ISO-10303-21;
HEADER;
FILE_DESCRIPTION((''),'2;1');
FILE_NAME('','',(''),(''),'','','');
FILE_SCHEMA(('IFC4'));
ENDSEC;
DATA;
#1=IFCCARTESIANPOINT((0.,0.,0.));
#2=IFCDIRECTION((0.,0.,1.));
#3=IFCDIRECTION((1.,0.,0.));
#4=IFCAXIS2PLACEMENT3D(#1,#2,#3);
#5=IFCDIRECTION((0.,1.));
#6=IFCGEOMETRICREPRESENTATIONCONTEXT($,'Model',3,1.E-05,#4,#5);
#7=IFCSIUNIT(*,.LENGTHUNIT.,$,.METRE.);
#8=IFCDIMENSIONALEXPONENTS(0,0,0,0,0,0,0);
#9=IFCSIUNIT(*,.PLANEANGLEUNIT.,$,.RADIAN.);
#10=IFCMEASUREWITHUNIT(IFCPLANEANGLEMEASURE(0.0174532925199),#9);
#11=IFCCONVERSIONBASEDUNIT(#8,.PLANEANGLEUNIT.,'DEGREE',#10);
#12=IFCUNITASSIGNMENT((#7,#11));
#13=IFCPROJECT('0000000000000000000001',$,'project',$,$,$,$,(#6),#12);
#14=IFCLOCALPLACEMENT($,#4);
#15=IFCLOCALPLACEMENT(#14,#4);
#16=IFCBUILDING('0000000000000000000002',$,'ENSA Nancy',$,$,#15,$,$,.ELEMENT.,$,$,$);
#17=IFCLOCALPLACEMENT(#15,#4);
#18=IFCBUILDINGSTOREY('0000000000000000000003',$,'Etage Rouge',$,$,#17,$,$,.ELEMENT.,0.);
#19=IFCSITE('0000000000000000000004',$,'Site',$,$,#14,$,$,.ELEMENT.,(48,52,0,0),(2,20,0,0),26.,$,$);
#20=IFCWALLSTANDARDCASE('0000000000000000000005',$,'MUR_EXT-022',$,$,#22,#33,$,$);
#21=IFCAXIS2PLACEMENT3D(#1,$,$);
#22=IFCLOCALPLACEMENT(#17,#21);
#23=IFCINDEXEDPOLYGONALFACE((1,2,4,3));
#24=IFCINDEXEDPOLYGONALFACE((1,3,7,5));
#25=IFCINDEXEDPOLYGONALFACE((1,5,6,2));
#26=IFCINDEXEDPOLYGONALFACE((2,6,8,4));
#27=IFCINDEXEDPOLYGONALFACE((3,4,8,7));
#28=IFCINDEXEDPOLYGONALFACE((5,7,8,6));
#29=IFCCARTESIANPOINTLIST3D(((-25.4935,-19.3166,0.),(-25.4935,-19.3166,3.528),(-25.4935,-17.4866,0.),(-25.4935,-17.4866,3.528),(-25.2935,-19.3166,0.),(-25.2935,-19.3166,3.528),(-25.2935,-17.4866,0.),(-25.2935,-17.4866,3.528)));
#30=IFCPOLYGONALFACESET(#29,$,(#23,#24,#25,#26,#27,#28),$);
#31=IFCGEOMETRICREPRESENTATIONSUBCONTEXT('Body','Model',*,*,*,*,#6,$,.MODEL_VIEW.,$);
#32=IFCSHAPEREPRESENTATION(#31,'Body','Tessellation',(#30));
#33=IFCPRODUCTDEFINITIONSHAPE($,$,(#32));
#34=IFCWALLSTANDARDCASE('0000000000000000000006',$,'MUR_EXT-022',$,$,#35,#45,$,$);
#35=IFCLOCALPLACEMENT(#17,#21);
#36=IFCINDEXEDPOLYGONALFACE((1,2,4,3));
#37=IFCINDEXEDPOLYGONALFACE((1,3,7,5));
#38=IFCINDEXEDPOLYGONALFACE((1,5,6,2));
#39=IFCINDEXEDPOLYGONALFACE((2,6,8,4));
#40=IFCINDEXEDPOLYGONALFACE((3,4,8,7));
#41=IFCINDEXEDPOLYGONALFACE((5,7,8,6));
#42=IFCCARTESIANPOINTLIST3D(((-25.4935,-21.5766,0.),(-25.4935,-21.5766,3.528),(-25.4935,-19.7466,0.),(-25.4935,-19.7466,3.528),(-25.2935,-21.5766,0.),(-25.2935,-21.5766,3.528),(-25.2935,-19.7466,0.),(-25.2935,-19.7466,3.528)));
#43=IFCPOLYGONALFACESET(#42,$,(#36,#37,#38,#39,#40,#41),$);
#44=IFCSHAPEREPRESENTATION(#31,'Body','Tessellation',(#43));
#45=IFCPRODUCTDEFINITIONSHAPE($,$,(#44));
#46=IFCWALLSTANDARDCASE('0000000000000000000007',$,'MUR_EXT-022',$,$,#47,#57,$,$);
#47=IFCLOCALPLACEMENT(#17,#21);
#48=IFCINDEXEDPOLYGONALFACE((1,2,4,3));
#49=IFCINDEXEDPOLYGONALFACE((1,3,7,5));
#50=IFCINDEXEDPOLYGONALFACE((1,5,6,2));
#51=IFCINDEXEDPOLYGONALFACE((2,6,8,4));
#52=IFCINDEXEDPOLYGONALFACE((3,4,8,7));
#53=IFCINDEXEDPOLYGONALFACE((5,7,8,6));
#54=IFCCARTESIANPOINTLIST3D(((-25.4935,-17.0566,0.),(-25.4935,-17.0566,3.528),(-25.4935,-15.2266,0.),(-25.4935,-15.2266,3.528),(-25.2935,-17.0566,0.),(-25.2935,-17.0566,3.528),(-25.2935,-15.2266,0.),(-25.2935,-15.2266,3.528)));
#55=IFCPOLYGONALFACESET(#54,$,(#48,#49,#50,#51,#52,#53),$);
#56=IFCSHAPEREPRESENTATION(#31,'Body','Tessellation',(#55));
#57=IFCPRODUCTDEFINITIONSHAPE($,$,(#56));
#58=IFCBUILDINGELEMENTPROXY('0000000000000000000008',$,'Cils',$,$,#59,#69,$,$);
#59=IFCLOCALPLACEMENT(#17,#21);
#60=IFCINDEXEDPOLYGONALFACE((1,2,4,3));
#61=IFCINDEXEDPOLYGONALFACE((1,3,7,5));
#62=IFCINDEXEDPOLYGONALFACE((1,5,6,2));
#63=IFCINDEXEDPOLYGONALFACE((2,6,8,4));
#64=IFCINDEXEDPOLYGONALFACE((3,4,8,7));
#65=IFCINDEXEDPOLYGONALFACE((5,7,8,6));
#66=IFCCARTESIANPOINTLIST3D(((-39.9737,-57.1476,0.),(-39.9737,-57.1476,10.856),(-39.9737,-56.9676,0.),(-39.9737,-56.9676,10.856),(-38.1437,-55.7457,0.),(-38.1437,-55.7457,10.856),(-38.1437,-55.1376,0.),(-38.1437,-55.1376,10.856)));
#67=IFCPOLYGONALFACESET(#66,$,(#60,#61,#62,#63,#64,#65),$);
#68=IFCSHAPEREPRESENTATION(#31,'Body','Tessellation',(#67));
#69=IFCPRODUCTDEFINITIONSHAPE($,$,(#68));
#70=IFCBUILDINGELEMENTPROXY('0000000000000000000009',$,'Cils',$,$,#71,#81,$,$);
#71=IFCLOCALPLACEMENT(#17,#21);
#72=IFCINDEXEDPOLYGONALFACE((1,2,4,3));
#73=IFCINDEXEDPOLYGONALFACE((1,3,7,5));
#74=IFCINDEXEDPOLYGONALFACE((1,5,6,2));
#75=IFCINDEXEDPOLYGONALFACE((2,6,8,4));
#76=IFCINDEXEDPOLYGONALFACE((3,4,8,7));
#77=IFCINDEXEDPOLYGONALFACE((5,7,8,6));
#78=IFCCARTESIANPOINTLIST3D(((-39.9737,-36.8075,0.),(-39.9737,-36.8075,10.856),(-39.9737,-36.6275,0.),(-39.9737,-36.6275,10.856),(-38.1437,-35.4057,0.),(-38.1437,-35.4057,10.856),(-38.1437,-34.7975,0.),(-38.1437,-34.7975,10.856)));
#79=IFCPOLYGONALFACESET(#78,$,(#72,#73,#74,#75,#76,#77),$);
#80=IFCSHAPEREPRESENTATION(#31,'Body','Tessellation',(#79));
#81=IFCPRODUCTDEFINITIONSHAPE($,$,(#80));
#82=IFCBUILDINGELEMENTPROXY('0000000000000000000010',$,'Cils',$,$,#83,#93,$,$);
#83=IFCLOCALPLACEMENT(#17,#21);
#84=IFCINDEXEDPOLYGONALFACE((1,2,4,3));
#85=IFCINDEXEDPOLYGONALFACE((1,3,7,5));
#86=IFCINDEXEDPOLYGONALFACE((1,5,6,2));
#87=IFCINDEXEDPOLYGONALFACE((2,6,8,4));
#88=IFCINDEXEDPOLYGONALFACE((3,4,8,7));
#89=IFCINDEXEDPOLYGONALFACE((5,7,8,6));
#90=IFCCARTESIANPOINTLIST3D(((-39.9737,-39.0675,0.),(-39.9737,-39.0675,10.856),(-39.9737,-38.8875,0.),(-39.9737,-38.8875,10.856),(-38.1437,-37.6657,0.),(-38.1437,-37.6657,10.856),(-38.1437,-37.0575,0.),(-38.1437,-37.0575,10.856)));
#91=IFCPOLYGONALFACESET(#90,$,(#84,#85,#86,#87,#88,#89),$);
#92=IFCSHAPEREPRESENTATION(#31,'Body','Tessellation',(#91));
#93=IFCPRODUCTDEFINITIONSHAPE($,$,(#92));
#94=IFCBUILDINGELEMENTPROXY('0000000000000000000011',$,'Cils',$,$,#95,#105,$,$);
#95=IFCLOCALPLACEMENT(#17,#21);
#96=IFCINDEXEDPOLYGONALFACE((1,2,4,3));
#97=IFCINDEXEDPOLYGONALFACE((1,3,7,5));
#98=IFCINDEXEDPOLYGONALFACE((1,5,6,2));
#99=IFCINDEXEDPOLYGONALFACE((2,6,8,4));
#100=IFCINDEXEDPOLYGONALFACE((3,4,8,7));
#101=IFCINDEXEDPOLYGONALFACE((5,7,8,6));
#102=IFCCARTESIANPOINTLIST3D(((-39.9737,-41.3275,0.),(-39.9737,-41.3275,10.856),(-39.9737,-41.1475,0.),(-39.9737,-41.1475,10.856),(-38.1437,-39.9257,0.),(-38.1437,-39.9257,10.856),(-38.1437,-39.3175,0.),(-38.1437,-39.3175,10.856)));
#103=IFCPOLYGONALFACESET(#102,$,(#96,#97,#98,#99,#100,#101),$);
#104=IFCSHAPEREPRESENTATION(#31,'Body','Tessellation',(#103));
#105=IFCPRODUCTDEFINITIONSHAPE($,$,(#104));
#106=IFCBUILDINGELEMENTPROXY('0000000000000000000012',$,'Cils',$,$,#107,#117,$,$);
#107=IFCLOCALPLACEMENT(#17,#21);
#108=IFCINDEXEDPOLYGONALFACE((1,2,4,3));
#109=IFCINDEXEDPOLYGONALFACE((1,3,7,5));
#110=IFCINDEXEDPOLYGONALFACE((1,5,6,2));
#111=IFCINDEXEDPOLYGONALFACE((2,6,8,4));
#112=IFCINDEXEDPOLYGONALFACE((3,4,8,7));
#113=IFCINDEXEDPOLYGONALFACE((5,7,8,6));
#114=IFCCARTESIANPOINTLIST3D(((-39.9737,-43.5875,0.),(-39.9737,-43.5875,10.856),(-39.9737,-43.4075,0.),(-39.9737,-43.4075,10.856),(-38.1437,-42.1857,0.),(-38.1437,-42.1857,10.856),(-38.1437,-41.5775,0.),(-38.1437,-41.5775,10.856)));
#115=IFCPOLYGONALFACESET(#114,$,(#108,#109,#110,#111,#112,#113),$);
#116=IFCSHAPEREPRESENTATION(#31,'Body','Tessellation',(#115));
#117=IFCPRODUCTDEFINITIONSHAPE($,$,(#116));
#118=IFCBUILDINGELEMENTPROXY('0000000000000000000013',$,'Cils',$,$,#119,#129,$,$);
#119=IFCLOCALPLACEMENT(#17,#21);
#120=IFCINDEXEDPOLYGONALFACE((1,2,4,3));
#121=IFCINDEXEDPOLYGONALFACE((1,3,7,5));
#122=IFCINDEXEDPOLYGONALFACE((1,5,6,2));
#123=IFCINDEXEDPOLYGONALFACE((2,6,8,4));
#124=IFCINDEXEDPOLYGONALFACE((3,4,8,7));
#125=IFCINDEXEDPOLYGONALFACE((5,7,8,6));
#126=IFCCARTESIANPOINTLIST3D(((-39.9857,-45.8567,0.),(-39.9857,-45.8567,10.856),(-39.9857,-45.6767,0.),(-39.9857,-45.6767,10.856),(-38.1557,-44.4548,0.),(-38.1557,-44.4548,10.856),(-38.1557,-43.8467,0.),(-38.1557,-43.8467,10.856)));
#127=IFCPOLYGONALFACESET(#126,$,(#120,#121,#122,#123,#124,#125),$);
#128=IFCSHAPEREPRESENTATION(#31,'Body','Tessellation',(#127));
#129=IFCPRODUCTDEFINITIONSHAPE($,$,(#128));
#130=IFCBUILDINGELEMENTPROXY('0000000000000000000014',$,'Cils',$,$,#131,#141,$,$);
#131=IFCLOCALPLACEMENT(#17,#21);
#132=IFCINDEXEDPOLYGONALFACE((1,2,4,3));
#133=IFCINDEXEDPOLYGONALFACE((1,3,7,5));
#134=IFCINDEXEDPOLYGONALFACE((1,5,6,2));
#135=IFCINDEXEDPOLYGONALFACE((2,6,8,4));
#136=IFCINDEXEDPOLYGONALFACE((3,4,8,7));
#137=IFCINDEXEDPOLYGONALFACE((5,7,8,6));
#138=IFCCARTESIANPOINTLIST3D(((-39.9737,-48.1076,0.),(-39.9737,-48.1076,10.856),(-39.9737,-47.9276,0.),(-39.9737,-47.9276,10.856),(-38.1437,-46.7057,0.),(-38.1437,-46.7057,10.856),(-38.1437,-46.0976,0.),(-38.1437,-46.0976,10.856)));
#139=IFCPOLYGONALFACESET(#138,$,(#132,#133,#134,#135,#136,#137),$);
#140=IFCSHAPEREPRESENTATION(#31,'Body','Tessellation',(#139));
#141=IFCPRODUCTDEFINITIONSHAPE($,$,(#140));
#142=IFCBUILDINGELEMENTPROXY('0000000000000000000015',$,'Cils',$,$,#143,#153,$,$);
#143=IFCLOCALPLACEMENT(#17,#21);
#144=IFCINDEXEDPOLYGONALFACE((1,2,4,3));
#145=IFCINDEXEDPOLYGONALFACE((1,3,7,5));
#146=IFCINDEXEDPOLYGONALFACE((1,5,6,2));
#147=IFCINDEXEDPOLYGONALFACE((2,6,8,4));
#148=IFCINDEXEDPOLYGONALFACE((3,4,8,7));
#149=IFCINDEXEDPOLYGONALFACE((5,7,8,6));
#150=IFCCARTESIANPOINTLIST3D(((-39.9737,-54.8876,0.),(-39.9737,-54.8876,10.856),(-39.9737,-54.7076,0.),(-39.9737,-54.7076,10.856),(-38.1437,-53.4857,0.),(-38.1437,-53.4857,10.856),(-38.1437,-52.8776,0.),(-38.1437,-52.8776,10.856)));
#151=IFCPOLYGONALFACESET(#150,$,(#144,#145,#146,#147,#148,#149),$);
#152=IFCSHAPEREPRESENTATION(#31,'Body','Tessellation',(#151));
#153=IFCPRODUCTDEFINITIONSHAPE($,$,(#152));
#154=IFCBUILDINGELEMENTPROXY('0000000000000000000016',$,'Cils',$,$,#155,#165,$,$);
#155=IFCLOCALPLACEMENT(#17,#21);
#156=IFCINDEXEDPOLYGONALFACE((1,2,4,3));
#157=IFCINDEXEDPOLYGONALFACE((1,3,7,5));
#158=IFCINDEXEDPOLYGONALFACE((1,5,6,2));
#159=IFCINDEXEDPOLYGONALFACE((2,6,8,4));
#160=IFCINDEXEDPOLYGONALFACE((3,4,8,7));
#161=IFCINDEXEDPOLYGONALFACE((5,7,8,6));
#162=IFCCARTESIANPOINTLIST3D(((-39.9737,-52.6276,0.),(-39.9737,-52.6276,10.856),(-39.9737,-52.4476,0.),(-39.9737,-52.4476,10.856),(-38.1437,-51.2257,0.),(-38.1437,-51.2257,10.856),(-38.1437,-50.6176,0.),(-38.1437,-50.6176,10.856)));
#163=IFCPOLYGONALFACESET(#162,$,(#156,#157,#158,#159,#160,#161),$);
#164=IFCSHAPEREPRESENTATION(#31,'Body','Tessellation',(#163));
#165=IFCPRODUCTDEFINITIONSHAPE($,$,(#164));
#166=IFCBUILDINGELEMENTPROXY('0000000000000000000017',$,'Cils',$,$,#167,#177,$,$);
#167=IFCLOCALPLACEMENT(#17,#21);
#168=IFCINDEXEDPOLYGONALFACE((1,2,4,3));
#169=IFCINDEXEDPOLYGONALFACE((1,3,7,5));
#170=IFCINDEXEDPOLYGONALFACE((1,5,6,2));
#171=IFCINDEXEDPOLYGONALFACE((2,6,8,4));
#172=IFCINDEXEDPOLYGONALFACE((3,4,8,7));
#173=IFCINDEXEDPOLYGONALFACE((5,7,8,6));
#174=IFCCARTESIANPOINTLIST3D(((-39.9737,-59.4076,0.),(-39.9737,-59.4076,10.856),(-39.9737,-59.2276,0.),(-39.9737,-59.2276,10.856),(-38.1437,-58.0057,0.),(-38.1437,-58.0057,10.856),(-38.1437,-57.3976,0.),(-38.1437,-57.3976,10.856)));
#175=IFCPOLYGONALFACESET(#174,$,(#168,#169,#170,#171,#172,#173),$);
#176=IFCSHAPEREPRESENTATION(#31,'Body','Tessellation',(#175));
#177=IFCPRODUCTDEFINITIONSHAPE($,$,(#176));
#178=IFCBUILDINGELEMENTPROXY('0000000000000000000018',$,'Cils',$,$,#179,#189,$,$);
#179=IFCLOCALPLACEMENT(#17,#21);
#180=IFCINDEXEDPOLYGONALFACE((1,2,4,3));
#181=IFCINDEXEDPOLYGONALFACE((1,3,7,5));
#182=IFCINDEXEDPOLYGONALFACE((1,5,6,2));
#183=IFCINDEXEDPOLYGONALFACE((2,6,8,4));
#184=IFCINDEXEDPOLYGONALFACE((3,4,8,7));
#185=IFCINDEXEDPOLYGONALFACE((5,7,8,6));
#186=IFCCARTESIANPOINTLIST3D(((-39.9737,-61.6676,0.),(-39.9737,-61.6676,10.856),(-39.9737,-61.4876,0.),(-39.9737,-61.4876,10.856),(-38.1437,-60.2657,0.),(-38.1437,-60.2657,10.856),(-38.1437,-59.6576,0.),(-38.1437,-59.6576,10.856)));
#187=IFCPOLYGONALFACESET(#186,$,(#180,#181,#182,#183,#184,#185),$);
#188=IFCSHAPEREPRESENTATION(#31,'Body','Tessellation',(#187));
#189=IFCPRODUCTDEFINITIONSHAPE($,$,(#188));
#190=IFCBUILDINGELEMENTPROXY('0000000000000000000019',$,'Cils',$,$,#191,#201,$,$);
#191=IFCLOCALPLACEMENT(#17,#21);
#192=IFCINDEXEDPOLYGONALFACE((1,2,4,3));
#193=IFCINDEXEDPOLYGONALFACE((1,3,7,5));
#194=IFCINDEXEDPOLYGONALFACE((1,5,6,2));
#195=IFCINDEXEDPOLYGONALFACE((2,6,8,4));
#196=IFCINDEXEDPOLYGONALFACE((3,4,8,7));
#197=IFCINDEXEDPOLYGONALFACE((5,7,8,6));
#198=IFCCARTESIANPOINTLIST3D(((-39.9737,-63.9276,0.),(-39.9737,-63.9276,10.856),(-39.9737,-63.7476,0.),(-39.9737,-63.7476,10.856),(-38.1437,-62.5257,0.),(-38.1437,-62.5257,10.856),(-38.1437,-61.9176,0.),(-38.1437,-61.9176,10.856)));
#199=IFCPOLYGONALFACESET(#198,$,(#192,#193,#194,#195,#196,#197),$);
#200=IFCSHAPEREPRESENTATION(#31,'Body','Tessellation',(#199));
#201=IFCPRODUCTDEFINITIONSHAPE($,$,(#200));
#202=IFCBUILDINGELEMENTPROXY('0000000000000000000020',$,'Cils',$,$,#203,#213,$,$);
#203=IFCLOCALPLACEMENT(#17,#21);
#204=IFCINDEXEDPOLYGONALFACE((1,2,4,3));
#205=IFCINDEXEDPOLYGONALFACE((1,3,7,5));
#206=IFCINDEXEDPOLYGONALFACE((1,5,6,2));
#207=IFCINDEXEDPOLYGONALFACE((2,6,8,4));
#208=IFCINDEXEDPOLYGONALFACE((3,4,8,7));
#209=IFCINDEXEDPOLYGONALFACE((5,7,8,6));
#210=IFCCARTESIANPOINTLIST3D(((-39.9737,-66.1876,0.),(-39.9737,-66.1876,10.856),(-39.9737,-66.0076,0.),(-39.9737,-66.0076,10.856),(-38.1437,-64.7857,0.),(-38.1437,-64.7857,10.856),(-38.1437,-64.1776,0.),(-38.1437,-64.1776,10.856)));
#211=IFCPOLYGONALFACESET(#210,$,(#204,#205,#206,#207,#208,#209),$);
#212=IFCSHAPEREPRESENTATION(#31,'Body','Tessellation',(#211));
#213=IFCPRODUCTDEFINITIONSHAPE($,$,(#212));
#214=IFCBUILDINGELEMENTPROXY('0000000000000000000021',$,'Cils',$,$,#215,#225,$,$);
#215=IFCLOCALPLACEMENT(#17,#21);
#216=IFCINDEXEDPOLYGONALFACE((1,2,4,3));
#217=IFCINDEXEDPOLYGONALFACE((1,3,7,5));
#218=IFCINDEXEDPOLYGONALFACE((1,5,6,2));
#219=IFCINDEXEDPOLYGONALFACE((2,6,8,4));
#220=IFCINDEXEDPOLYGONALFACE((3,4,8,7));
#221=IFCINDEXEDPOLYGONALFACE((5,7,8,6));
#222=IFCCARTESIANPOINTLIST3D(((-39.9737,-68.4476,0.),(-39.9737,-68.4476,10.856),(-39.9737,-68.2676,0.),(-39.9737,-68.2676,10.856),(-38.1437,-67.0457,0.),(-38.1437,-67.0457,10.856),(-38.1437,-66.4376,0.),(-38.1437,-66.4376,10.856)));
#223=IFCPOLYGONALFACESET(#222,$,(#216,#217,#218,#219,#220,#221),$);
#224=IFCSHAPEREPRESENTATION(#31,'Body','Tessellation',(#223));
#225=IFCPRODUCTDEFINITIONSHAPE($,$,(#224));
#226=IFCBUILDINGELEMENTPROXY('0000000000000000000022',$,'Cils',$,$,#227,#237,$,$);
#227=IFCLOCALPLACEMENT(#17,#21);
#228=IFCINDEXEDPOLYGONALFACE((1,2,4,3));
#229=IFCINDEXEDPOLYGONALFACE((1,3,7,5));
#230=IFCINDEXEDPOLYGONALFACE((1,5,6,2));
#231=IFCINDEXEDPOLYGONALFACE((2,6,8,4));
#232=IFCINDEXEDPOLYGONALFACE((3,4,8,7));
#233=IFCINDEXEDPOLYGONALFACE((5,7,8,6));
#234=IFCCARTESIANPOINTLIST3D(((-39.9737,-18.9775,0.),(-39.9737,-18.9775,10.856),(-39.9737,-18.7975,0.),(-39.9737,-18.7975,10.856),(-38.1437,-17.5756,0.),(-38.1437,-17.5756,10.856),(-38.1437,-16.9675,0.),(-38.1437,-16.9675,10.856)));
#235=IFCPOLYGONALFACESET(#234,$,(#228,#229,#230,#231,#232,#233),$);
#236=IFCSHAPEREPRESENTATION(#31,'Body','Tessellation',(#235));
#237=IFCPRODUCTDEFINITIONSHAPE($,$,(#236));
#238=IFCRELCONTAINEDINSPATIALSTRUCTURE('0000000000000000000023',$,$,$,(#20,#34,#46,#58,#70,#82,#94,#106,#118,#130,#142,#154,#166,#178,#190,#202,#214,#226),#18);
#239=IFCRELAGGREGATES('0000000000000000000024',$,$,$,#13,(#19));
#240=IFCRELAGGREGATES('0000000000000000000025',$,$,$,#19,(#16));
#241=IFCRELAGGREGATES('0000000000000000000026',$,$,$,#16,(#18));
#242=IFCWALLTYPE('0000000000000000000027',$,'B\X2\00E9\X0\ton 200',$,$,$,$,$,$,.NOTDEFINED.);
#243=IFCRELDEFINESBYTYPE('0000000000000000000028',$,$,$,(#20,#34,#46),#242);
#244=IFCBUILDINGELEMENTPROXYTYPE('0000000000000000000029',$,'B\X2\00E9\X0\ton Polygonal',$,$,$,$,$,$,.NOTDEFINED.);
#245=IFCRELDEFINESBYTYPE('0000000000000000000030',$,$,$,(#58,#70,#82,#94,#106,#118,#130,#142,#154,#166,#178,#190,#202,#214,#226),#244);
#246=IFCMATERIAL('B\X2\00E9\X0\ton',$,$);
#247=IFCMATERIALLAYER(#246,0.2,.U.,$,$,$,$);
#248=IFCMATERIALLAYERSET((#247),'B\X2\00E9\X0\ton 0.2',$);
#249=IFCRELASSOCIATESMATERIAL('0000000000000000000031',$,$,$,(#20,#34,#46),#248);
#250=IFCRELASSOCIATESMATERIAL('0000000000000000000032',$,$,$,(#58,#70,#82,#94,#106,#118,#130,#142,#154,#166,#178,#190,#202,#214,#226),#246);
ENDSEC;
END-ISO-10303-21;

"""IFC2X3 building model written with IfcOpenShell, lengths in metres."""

from ifc_helpers import new_model, entity, si_unit, converted_unit, direction, frame, origin_with_axes, place, context, subcontext, project, spatial, polyline, outline, extrude, material, layer, layer_set, layer_usage, type_object, element, save


model = new_model("IFC2X3")

# Units and contexts
model_context = context("Model", 3, precision=1e-05, world=origin_with_axes(), true_north=direction((0.0, 1.0)))
body_context = subcontext(model_context, "Body", "Model", "MODEL_VIEW")
ifc_project = project(units=[si_unit("LENGTHUNIT", "METRE"), converted_unit("PLANEANGLEUNIT", "DEGREE", entity("IfcPlaneAngleMeasure", 0.0174532925199), si_unit("PLANEANGLEUNIT", "RADIAN"), dimensions=[0, 0, 0, 0, 0, 0, 0])], contexts=[model_context])

# Site, building, storey
site_placement = place(None, origin_with_axes())
site = spatial("IfcSite", under=ifc_project, at=site_placement, Name="Site", CompositionType="ELEMENT", RefLatitude=(48, 52, 0, 0), RefLongitude=(2, 20, 0, 0), RefElevation=26.0)
building_placement = place(site_placement, origin_with_axes())
building = spatial("IfcBuilding", under=site, at=building_placement, Name="ENSA Nancy", CompositionType="ELEMENT")
storey_placement = place(building_placement, origin_with_axes())
storey = spatial("IfcBuildingStorey", under=building, at=storey_placement, Name="Etage Rouge", CompositionType="ELEMENT", Elevation=0.0)

# Walls
ifc_material = material(Name="Béton")
ifc_layer = layer(ifc_material, 0.2, ventilated="UNKNOWN")
ifc_layer_set = layer_set([ifc_layer], Name="Béton 0.2")
ifc_layer_usage_1 = layer_usage(ifc_layer_set, "AXIS2", "POSITIVE", -0.2)
wall_type = type_object("IfcWallType", Name="Béton 200", PredefinedType="NOTDEFINED")
wall_1_placement = place(storey_placement, frame((-25.2935, -17.4866, 0.0), z_axis=(0.0, 0.0, 1.0), x_axis=(0.0, -1.0, 0.0)))
element("IfcWallStandardCase", 1, at=wall_1_placement, inside=storey, type_object=wall_type, material=ifc_layer_usage_1, Name="MUR_EXT-022", context=body_context, shape_type="SweptSolid", body=[
    extrude(outline(polyline([(0.0, -0.2), (1.83, -0.2), (1.83, 0.0), (0.0, 0.0), (0.0, -0.2)])), origin_with_axes(), (0.0, 0.0, 1.0), 3.528),
])
ifc_layer_usage_2 = layer_usage(ifc_layer_set, "AXIS2", "POSITIVE", -0.2)
wall_2_placement = place(storey_placement, frame((-25.2935, -19.7466, 0.0), z_axis=(0.0, 0.0, 1.0), x_axis=(0.0, -1.0, 0.0)))
element("IfcWallStandardCase", 2, at=wall_2_placement, inside=storey, type_object=wall_type, material=ifc_layer_usage_2, Name="MUR_EXT-022", context=body_context, shape_type="SweptSolid", body=[
    extrude(outline(polyline([(0.0, -0.2), (1.83, -0.2), (1.83, 0.0), (0.0, 0.0), (0.0, -0.2)])), origin_with_axes(), (0.0, 0.0, 1.0), 3.528),
])
ifc_layer_usage_3 = layer_usage(ifc_layer_set, "AXIS2", "POSITIVE", -0.2)
wall_3_placement = place(storey_placement, frame((-25.2935, -15.2266, 0.0), z_axis=(0.0, 0.0, 1.0), x_axis=(0.0, -1.0, 0.0)))
element("IfcWallStandardCase", 3, at=wall_3_placement, inside=storey, type_object=wall_type, material=ifc_layer_usage_3, Name="MUR_EXT-022", context=body_context, shape_type="SweptSolid", body=[
    extrude(outline(polyline([(0.0, -0.2), (1.83, -0.2), (1.83, 0.0), (0.0, 0.0), (0.0, -0.2)])), origin_with_axes(), (0.0, 0.0, 1.0), 3.528),
])

# Building element proxies
building_element_proxy_type = type_object("IfcBuildingElementProxyType", Name="Béton Polygonal", PredefinedType="NOTDEFINED")
for number, where, z_axis, x_axis, name in (
    (4, (-38.1437, -55.1376, 0.0), (0.0, 0.0, 1.0), (-0.707107, -0.707107, 0.0), "Cils"),
    (5, (-38.1437, -34.7975, 0.0), (0.0, 0.0, 1.0), (-0.707107, -0.707107, 0.0), "Cils"),
    (6, (-38.1437, -37.0575, 0.0), (0.0, 0.0, 1.0), (-0.707107, -0.707107, 0.0), "Cils"),
    (7, (-38.1437, -39.3175, 0.0), (0.0, 0.0, 1.0), (-0.707107, -0.707107, 0.0), "Cils"),
    (8, (-38.1437, -41.5775, 0.0), (0.0, 0.0, 1.0), (-0.707107, -0.707107, 0.0), "Cils"),
    (9, (-38.1557, -43.8467, 0.0), (0.0, 0.0, 1.0), (-0.707107, -0.707107, 0.0), "Cils"),
    (10, (-38.1437, -46.0976, 0.0), (0.0, 0.0, 1.0), (-0.707107, -0.707107, 0.0), "Cils"),
    (11, (-38.1437, -52.8776, 0.0), (0.0, 0.0, 1.0), (-0.707107, -0.707107, 0.0), "Cils"),
    (12, (-38.1437, -50.6176, 0.0), (0.0, 0.0, 1.0), (-0.707107, -0.707107, 0.0), "Cils"),
    (13, (-38.1437, -57.3976, 0.0), (0.0, 0.0, 1.0), (-0.707107, -0.707107, 0.0), "Cils"),
    (14, (-38.1437, -59.6576, 0.0), (0.0, 0.0, 1.0), (-0.707107, -0.707107, 0.0), "Cils"),
    (15, (-38.1437, -61.9176, 0.0), (0.0, 0.0, 1.0), (-0.707107, -0.707107, 0.0), "Cils"),
    (16, (-38.1437, -64.1776, 0.0), (0.0, 0.0, 1.0), (-0.707107, -0.707107, 0.0), "Cils"),
    (17, (-38.1437, -66.4376, 0.0), (0.0, 0.0, 1.0), (-0.707107, -0.707107, 0.0), "Cils"),
    (18, (-38.1437, -16.9675, 0.0), (0.0, 0.0, 1.0), (-0.707107, -0.707107, 0.0), "Cils"),
):
    element("IfcBuildingElementProxy", number, at=place(storey_placement, frame(where, z_axis=z_axis, x_axis=x_axis)), inside=storey, type_object=building_element_proxy_type, material=ifc_material, Name=name, context=body_context, shape_type="SweptSolid", body=[
        extrude(outline(polyline([(0.0, 0.0), (2.588, 0.0), (2.7153, 0.1273), (0.43, 0.43), (0.0, 0.0)])), origin_with_axes(), (0.0, 0.0, 1.0), 10.856),
    ])

save(model, "model.ifc")
